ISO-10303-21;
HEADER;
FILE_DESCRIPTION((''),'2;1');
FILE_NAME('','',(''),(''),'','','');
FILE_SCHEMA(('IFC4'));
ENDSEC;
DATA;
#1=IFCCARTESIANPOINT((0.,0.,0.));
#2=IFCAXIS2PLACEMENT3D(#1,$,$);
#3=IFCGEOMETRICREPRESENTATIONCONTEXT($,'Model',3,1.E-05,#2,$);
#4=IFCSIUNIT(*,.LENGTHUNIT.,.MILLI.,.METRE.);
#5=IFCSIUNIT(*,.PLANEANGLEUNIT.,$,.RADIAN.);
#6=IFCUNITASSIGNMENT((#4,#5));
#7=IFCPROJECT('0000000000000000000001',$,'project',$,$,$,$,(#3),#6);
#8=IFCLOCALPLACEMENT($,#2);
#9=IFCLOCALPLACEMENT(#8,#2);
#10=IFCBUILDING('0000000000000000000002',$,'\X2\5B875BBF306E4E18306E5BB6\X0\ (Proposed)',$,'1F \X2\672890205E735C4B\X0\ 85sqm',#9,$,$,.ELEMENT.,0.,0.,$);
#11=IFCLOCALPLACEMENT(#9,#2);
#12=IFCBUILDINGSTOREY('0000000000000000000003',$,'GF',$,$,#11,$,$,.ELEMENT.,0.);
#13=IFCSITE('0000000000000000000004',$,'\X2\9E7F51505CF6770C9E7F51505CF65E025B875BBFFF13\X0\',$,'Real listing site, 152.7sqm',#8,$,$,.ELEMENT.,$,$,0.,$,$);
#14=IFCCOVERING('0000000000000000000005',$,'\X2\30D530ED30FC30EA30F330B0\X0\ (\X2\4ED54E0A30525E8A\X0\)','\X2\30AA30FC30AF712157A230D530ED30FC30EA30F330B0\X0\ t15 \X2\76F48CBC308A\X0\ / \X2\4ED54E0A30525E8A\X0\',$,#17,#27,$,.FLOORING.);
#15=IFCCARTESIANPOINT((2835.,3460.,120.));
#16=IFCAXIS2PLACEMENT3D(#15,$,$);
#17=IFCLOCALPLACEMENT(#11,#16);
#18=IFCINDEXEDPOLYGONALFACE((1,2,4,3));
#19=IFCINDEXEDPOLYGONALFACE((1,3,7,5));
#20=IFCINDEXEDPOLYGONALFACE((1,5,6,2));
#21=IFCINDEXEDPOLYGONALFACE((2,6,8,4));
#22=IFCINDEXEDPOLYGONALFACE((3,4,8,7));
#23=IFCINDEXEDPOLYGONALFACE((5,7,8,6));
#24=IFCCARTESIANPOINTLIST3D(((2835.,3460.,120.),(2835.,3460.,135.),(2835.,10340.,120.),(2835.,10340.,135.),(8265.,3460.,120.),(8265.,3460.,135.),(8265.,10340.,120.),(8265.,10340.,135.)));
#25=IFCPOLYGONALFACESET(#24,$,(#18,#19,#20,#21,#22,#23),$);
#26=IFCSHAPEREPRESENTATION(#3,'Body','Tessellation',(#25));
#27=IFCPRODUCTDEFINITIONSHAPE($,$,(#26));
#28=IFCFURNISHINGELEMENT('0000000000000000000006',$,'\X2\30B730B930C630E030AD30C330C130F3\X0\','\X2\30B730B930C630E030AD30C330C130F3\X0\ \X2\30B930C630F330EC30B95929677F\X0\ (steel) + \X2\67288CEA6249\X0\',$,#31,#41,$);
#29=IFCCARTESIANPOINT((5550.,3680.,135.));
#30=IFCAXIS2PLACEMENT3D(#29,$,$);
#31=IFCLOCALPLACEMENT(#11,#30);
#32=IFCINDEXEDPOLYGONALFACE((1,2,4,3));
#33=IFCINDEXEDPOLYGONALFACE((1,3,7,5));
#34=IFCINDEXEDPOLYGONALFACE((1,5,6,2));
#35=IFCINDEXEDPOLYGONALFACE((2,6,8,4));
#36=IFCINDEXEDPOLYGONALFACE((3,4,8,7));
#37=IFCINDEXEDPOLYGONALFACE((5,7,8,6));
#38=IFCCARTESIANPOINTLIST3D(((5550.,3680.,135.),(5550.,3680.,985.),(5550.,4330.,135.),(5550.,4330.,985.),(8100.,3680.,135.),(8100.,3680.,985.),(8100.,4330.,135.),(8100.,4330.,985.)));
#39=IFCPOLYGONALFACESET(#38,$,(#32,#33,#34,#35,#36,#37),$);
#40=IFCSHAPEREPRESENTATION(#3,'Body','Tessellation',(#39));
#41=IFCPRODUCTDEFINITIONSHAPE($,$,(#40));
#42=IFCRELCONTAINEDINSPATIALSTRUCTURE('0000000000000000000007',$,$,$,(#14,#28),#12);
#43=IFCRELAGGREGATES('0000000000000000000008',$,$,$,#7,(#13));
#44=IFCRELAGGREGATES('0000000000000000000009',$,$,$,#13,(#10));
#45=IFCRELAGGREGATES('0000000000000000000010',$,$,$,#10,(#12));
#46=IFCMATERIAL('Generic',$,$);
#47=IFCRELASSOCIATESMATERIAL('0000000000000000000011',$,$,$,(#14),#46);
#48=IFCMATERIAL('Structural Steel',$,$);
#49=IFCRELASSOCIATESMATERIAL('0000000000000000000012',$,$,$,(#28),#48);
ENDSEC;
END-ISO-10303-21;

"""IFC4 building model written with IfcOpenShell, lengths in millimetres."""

from ifc_helpers import new_model, si_unit, frame, frame_2d, origin, place, context, project, spatial, rectangle, extrude, material, element, save


model = new_model("IFC4")

# Units and contexts
model_context = context("Model", 3, precision=1e-05, world=origin())
ifc_project = project(units=[si_unit("LENGTHUNIT", "METRE", prefix="MILLI"), si_unit("PLANEANGLEUNIT", "RADIAN")], contexts=[model_context])

# Site, building, storey
site_placement = place(None, origin())
site = spatial("IfcSite", under=ifc_project, at=site_placement, Name="鹿児島県鹿児島市宇宿３", ObjectType="Real listing site, 152.7sqm", CompositionType="ELEMENT", RefElevation=0.0)
building_placement = place(site_placement, origin())
building = spatial("IfcBuilding", under=site, at=building_placement, Name="宇宿の丘の家 (Proposed)", ObjectType="1F 木造平屋 85sqm", CompositionType="ELEMENT", ElevationOfRefHeight=0.0, ElevationOfTerrain=0.0)
storey_placement = place(building_placement, origin())
storey = spatial("IfcBuildingStorey", under=building, at=storey_placement, Name="GF", CompositionType="ELEMENT", Elevation=0.0)

# Shared definitions
ifc_material_1 = material(Name="Generic")

# Covering
covering_placement = place(storey_placement, frame((2835.0, 3460.0, 120.0)))
element("IfcCovering", 1, at=covering_placement, inside=storey, material=ifc_material_1, Name="フローリング (仕上げ床)", Description="オーク無垢フローリング t15 直貼り / 仕上げ床", PredefinedType="FLOORING", context=model_context, shape_type="SweptSolid", body=[
    extrude(rectangle(XDim=5430.0, YDim=6880.0, at=frame_2d((2715.0, 3440.0))), frame((2835.0, 3460.0, 120.0)), (0.0, 0.0, 1.0), 15.0),
])

# Furnishing element
ifc_material_2 = material(Name="Structural Steel")
furnishing_placement = place(storey_placement, frame((5550.0, 3680.0, 135.0)))
element("IfcFurnishingElement", 2, at=furnishing_placement, inside=storey, material=ifc_material_2, Name="システムキッチン", Description="システムキッチン ステンレス天板 (steel) + 木質扉", context=model_context, shape_type="SweptSolid", body=[
    extrude(rectangle(XDim=2550.0, YDim=650.0, at=frame_2d((1275.0, 325.0))), frame((5550.0, 3680.0, 135.0)), (0.0, 0.0, 1.0), 850.0),
])

save(model, "model.ifc")
